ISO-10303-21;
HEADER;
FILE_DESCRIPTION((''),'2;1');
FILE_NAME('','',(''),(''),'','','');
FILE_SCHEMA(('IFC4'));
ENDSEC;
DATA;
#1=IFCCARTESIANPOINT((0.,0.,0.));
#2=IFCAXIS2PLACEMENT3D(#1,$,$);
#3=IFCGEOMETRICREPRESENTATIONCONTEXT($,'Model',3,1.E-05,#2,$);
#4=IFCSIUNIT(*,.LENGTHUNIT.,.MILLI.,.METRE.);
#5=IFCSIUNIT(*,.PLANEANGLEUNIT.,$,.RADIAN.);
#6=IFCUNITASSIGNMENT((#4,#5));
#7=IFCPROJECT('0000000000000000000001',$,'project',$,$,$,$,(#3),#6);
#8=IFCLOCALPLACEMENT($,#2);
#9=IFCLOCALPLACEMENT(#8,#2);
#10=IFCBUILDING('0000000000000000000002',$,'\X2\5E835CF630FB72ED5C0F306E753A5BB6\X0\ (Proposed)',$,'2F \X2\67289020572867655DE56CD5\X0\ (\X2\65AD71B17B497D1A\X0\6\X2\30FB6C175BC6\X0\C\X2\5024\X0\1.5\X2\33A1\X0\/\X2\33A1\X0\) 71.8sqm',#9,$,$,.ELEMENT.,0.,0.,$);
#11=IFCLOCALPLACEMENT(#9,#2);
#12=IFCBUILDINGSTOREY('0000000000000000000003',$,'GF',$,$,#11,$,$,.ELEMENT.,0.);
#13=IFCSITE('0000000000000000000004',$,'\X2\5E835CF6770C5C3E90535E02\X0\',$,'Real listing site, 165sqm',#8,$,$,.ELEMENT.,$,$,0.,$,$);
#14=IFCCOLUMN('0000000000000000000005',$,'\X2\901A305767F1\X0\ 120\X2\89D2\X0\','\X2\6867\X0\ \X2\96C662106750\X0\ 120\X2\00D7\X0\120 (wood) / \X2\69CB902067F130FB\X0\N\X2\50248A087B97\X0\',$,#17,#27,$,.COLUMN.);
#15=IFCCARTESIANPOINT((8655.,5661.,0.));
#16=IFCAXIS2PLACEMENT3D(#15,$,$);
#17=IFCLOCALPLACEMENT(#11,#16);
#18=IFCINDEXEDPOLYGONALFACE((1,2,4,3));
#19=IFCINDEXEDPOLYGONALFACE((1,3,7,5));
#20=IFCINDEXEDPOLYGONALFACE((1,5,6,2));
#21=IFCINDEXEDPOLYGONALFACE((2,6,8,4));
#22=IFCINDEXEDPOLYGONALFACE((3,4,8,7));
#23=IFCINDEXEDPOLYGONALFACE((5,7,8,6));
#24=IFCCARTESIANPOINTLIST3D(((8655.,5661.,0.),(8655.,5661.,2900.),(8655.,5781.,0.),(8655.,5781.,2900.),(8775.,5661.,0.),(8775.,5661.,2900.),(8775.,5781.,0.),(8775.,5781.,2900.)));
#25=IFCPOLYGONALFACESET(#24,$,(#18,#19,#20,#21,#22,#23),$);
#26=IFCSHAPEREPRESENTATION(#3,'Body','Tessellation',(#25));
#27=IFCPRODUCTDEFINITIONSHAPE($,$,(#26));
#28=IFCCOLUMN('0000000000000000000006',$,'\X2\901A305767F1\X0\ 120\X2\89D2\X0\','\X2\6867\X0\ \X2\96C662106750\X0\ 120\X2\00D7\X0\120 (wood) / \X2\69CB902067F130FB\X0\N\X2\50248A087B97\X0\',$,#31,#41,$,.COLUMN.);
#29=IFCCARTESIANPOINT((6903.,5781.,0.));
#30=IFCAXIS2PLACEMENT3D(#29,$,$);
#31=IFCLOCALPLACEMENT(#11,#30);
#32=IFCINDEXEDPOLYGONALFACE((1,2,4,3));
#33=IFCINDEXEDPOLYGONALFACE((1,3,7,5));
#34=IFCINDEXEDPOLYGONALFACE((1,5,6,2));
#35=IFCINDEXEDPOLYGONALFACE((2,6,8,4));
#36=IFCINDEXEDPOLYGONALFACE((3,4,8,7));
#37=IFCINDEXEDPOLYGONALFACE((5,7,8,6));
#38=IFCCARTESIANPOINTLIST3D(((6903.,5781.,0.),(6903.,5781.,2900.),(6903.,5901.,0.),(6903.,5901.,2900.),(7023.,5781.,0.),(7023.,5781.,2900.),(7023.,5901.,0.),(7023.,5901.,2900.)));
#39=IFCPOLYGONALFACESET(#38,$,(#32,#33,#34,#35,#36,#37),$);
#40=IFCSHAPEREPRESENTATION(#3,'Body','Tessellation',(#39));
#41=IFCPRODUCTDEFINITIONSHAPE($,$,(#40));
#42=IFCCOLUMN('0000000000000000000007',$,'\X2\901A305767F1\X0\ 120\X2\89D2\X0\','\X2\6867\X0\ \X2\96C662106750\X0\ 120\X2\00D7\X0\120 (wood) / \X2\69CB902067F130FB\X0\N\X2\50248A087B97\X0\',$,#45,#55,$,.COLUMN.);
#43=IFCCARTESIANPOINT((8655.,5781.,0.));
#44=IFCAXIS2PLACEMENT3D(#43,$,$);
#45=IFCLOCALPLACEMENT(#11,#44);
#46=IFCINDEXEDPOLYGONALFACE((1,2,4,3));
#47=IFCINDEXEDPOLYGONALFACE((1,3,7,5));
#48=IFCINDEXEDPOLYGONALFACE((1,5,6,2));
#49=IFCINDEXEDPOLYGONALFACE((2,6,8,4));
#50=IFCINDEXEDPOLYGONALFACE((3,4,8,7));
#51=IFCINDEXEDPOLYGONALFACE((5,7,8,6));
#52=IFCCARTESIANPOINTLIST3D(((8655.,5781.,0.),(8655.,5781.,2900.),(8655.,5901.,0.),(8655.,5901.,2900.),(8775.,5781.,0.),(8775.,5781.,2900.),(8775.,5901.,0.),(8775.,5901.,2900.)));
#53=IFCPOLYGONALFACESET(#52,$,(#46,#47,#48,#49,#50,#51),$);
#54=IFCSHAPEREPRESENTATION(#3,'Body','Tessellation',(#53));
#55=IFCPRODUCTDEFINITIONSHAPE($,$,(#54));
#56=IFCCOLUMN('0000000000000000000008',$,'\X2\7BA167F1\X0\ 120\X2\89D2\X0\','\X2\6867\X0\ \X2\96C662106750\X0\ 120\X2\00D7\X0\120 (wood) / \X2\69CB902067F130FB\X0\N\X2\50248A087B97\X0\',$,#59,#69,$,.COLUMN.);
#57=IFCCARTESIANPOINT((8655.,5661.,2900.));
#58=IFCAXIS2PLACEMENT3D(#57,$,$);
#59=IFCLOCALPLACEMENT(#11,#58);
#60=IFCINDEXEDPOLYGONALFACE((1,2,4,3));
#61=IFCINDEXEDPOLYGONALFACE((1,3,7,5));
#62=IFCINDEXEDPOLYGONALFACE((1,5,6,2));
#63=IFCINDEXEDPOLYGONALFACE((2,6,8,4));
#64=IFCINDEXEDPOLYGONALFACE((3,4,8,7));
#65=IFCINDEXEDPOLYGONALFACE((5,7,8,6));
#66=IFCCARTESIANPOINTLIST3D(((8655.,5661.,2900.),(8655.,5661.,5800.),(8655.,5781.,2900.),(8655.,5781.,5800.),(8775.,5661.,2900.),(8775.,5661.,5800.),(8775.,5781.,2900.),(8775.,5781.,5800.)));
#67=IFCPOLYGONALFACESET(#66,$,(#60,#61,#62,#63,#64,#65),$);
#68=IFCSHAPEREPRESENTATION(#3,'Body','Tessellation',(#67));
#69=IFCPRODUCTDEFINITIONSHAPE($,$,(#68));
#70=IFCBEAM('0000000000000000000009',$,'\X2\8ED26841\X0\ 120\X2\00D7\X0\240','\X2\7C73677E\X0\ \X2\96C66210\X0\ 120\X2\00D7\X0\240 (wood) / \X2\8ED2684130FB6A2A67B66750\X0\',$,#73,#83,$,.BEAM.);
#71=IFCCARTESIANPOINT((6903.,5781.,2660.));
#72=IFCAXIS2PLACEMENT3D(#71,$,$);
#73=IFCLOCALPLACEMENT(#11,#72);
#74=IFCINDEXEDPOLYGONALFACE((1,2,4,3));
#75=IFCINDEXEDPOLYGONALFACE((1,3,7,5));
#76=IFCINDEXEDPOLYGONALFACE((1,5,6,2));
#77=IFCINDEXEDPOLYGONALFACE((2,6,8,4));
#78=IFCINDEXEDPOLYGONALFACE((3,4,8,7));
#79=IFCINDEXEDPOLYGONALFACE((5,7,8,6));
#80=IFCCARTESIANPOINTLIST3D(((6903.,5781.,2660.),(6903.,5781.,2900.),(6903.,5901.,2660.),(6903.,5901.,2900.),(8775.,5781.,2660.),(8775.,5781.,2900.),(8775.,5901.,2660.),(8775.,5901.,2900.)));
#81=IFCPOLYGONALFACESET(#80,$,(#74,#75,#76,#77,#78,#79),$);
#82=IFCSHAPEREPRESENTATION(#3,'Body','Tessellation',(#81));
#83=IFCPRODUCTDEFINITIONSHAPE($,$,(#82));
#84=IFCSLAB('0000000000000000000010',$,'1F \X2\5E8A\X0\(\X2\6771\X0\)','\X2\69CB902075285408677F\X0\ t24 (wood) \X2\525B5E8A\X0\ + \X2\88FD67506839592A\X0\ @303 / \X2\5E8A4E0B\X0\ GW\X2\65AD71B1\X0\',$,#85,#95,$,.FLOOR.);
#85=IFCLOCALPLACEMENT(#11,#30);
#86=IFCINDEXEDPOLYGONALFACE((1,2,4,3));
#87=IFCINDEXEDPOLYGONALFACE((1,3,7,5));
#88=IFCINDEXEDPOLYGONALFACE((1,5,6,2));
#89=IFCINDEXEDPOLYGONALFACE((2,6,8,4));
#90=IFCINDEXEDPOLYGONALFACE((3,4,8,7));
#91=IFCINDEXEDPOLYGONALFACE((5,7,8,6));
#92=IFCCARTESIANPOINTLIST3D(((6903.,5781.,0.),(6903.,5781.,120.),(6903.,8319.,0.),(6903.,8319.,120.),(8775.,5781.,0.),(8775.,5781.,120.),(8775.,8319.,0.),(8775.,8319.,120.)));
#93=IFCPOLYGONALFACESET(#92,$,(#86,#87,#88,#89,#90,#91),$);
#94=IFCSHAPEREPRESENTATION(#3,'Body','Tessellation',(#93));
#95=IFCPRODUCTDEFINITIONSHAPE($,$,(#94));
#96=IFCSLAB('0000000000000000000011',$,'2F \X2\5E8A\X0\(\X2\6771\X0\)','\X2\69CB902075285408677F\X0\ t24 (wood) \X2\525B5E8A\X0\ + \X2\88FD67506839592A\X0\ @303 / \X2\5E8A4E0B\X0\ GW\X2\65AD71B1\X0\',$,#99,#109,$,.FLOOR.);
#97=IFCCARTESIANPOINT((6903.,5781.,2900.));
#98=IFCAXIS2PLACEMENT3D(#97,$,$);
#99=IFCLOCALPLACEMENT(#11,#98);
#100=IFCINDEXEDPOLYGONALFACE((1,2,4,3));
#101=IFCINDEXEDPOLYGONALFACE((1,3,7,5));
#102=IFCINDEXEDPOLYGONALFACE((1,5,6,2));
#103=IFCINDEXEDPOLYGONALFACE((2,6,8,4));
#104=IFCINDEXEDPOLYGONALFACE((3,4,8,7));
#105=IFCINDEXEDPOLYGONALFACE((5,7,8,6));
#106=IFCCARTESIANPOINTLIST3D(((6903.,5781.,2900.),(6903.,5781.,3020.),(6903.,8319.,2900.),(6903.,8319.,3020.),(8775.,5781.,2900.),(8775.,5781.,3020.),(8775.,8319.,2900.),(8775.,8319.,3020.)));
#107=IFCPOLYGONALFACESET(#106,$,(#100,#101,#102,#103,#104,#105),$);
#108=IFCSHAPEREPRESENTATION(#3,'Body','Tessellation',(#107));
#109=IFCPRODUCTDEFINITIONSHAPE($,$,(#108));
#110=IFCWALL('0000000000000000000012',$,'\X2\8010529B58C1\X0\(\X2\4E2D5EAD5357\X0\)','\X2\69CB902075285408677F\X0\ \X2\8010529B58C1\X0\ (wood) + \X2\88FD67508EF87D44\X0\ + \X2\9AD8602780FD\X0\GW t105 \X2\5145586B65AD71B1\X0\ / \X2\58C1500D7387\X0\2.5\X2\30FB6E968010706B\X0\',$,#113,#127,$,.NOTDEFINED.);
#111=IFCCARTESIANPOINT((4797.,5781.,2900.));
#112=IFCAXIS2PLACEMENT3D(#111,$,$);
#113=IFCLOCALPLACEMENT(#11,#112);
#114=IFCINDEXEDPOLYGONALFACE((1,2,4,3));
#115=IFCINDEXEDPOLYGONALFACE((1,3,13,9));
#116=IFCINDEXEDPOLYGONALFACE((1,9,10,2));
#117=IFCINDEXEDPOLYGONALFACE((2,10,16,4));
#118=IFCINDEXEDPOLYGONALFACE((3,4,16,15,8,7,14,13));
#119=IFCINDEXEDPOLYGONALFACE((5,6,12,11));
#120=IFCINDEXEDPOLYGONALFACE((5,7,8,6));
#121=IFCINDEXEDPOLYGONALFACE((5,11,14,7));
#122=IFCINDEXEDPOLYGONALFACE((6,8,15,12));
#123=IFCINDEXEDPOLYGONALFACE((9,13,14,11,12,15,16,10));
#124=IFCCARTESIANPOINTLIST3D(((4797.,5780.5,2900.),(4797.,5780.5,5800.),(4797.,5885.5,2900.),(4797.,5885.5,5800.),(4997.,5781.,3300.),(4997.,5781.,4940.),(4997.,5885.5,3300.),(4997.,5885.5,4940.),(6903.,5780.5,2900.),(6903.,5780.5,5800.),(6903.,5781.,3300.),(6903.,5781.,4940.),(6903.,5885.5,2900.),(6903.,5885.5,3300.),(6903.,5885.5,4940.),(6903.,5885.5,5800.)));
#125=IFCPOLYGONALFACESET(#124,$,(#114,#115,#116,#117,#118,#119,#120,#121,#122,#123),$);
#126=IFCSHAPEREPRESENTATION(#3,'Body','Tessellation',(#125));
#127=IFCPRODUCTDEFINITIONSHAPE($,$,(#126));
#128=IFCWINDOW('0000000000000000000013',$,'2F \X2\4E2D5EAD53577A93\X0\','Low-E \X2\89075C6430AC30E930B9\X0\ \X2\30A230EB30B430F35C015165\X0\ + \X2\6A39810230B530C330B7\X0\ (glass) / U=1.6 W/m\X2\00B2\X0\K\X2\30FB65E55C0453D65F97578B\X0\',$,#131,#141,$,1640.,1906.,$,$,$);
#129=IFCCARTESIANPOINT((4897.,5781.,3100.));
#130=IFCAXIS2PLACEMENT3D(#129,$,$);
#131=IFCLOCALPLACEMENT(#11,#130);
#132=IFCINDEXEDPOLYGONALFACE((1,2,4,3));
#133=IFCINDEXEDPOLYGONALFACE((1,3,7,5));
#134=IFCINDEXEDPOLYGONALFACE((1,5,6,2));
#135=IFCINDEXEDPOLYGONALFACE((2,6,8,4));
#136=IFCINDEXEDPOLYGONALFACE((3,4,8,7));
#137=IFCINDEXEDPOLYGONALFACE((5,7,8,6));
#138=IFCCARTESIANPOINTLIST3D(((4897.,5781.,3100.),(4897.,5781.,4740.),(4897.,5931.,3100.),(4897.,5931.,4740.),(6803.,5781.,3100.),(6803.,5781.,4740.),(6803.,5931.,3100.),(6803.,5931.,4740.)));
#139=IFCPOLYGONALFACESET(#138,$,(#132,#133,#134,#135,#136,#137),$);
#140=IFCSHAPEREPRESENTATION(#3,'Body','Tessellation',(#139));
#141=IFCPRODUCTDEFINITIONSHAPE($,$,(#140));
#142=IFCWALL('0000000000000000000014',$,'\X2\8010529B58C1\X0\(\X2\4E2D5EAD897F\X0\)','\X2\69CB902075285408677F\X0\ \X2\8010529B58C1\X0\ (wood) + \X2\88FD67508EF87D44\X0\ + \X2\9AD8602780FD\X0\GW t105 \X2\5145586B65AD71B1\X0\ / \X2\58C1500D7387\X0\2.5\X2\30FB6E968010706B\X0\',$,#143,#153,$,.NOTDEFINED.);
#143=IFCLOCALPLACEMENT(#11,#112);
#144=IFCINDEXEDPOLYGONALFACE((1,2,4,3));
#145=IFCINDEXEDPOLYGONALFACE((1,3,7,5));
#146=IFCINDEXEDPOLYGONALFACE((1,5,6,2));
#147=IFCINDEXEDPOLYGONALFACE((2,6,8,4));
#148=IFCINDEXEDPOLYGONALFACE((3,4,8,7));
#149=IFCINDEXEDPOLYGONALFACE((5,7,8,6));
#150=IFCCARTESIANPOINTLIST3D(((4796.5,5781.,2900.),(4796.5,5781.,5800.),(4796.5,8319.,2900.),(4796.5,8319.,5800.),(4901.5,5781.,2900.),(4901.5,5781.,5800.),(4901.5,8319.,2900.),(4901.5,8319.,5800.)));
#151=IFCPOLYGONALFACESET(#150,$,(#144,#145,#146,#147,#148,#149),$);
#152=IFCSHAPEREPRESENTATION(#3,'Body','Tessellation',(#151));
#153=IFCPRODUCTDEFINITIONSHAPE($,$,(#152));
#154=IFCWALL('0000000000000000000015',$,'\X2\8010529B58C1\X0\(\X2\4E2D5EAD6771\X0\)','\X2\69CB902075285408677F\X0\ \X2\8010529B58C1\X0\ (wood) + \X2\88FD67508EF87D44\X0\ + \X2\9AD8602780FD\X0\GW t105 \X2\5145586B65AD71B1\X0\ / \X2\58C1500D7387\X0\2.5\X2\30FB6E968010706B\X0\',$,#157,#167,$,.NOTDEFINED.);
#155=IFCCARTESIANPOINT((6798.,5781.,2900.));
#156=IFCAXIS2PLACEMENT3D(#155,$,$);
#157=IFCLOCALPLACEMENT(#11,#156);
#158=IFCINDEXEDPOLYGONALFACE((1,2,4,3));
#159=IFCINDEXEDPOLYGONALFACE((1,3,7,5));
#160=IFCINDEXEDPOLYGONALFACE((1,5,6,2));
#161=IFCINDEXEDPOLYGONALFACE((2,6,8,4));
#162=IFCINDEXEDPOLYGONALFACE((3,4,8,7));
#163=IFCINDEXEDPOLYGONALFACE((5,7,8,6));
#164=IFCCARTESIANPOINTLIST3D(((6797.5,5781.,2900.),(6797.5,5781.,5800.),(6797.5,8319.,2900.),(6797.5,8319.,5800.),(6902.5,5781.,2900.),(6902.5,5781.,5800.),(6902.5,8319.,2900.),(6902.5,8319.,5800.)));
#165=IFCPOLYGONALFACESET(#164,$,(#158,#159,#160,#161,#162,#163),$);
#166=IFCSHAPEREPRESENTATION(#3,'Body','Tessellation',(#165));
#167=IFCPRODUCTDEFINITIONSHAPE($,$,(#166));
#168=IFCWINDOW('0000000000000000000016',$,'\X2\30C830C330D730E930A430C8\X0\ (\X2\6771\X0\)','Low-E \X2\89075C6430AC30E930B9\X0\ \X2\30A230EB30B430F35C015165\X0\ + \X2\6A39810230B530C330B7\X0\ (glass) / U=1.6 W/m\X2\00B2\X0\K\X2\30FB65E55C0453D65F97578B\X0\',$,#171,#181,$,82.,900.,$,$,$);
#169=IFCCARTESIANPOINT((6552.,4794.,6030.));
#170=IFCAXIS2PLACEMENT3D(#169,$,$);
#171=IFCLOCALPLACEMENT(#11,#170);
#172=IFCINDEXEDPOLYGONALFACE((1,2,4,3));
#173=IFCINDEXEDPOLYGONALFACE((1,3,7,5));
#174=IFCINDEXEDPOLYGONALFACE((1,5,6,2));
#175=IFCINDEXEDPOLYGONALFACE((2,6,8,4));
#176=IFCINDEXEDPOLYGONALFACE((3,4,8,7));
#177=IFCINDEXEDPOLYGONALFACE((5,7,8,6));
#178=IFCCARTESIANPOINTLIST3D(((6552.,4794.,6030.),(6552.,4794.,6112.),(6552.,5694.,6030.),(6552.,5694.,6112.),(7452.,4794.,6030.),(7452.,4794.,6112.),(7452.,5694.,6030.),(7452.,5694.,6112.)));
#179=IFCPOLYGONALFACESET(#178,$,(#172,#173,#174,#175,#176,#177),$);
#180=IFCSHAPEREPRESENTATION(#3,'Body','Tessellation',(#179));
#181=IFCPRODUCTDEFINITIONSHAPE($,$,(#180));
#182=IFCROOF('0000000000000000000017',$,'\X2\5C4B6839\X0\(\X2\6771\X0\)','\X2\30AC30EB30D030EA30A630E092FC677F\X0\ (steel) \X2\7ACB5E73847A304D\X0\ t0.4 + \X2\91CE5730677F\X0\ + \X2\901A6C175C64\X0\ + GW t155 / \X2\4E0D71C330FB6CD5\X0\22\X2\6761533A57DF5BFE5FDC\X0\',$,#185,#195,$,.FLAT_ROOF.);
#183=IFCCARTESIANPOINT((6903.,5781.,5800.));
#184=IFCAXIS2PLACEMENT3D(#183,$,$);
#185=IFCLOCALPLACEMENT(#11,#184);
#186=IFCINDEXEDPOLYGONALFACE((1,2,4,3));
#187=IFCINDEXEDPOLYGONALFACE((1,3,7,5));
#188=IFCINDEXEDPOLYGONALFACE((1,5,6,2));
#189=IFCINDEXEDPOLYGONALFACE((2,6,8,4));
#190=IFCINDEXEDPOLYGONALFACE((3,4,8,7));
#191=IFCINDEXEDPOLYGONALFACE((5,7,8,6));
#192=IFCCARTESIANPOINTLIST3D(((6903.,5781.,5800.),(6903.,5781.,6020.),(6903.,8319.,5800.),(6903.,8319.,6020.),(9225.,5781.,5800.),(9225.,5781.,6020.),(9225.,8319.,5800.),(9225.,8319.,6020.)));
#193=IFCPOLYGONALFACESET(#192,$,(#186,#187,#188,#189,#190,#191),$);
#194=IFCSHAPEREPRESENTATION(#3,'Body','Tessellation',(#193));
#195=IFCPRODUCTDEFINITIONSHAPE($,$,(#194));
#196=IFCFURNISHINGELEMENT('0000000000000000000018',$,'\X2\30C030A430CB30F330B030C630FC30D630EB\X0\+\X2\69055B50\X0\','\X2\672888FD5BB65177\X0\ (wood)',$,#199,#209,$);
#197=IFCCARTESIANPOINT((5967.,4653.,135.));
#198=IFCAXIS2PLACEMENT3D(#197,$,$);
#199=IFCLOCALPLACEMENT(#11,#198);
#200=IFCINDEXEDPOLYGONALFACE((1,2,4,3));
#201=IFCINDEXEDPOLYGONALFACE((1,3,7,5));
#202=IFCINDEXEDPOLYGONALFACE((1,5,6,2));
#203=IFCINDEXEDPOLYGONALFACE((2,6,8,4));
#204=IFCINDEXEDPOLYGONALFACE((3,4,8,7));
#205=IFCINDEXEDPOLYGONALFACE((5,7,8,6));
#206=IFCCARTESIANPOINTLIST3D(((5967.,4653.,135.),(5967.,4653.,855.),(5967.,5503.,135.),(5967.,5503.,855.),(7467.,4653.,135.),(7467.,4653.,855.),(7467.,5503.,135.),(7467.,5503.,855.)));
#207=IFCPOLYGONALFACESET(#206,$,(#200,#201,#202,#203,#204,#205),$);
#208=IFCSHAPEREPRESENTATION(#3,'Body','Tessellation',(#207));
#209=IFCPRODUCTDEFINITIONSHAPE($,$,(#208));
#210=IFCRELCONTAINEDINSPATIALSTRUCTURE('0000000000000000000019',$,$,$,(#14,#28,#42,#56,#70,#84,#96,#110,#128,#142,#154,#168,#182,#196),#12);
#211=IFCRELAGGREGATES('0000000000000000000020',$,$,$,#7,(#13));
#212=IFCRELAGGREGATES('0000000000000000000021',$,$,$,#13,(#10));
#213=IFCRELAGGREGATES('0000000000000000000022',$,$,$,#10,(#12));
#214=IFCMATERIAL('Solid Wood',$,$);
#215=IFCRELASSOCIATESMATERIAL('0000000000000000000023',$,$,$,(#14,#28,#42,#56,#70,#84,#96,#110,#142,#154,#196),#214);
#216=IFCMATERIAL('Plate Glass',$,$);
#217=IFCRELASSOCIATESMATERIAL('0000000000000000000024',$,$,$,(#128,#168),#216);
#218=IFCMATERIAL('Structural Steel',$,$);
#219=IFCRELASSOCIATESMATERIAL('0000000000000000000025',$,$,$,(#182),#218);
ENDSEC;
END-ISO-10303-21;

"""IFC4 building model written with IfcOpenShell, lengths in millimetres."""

from ifc_helpers import new_model, si_unit, frame, frame_2d, origin, place, context, project, spatial, rectangle, extrude, material, element, fill, save


model = new_model("IFC4")

# Units and contexts
model_context = context("Model", 3, precision=1e-05, world=origin())
ifc_project = project(units=[si_unit("LENGTHUNIT", "METRE", prefix="MILLI"), si_unit("PLANEANGLEUNIT", "RADIAN")], contexts=[model_context])

# Site, building, storey
site_placement = place(None, origin())
site = spatial("IfcSite", under=ifc_project, at=site_placement, Name="広島県尾道市", ObjectType="Real listing site, 165sqm", CompositionType="ELEMENT", RefElevation=0.0)
building_placement = place(site_placement, origin())
building = spatial("IfcBuilding", under=site, at=building_placement, Name="広島・狭小の町家 (Proposed)", ObjectType="2F 木造在来工法 (断熱等級6・気密C値1.5㎡/㎡) 71.8sqm", CompositionType="ELEMENT", ElevationOfRefHeight=0.0, ElevationOfTerrain=0.0)
storey_placement = place(building_placement, origin())
storey = spatial("IfcBuildingStorey", under=building, at=storey_placement, Name="GF", CompositionType="ELEMENT", Elevation=0.0)

# Columns
ifc_material_1 = material(Name="Solid Wood")
column_1_placement = place(storey_placement, frame((8655.0, 5661.0, 0.0)))
element("IfcColumn", 1, at=column_1_placement, inside=storey, material=ifc_material_1, Name="通し柱 120角", Description="桧 集成材 120×120 (wood) / 構造柱・N値計算", PredefinedType="COLUMN", context=model_context, shape_type="SweptSolid", body=[
    extrude(rectangle(XDim=120.0, YDim=120.0, at=frame_2d((60.0, 60.0))), frame((8655.0, 5661.0, 0.0)), (0.0, 0.0, 1.0), 2900.0),
])
column_2_placement = place(storey_placement, frame((6903.0, 5781.0, 0.0)))
element("IfcColumn", 2, at=column_2_placement, inside=storey, material=ifc_material_1, Name="通し柱 120角", Description="桧 集成材 120×120 (wood) / 構造柱・N値計算", PredefinedType="COLUMN", context=model_context, shape_type="SweptSolid", body=[
    extrude(rectangle(XDim=120.0, YDim=120.0, at=frame_2d((60.0, 60.0))), frame((6903.0, 5781.0, 0.0)), (0.0, 0.0, 1.0), 2900.0),
])
column_3_placement = place(storey_placement, frame((8655.0, 5781.0, 0.0)))
element("IfcColumn", 3, at=column_3_placement, inside=storey, material=ifc_material_1, Name="通し柱 120角", Description="桧 集成材 120×120 (wood) / 構造柱・N値計算", PredefinedType="COLUMN", context=model_context, shape_type="SweptSolid", body=[
    extrude(rectangle(XDim=120.0, YDim=120.0, at=frame_2d((60.0, 60.0))), frame((8655.0, 5781.0, 0.0)), (0.0, 0.0, 1.0), 2900.0),
])
column_4_placement = place(storey_placement, frame((8655.0, 5661.0, 2900.0)))
element("IfcColumn", 4, at=column_4_placement, inside=storey, material=ifc_material_1, Name="管柱 120角", Description="桧 集成材 120×120 (wood) / 構造柱・N値計算", PredefinedType="COLUMN", context=model_context, shape_type="SweptSolid", body=[
    extrude(rectangle(XDim=120.0, YDim=120.0, at=frame_2d((60.0, 60.0))), frame((8655.0, 5661.0, 2900.0)), (0.0, 0.0, 1.0), 2900.0),
])

# Beam
beam_1_placement = place(storey_placement, frame((6903.0, 5781.0, 2660.0)))
element("IfcBeam", 5, at=beam_1_placement, inside=storey, material=ifc_material_1, Name="軒桁 120×240", Description="米松 集成 120×240 (wood) / 軒桁・横架材", PredefinedType="BEAM", context=model_context, shape_type="SweptSolid", body=[
    extrude(rectangle(XDim=1872.0, YDim=120.0, at=frame_2d((936.0, 60.0))), frame((6903.0, 5781.0, 2660.0)), (0.0, 0.0, 1.0), 240.0),
])

# Slabs
slab_1_placement = place(storey_placement, frame((6903.0, 5781.0, 0.0)))
element("IfcSlab", 6, at=slab_1_placement, inside=storey, material=ifc_material_1, Name="1F 床(東)", Description="構造用合板 t24 (wood) 剛床 + 製材根太 @303 / 床下 GW断熱", PredefinedType="FLOOR", context=model_context, shape_type="SweptSolid", body=[
    extrude(rectangle(XDim=1872.0, YDim=2538.0, at=frame_2d((936.0, 1269.0))), frame((6903.0, 5781.0, 0.0)), (0.0, 0.0, 1.0), 120.0),
])
slab_2_placement = place(storey_placement, frame((6903.0, 5781.0, 2900.0)))
element("IfcSlab", 7, at=slab_2_placement, inside=storey, material=ifc_material_1, Name="2F 床(東)", Description="構造用合板 t24 (wood) 剛床 + 製材根太 @303 / 床下 GW断熱", PredefinedType="FLOOR", context=model_context, shape_type="SweptSolid", body=[
    extrude(rectangle(XDim=1872.0, YDim=2538.0, at=frame_2d((936.0, 1269.0))), frame((6903.0, 5781.0, 2900.0)), (0.0, 0.0, 1.0), 120.0),
])

# Wall, opening, window
wall_1_placement = place(storey_placement, frame((4797.0, 5781.0, 2900.0)))
wall_1 = element("IfcWall", 8, at=wall_1_placement, inside=storey, material=ifc_material_1, Name="耐力壁(中庭南)", Description="構造用合板 耐力壁 (wood) + 製材軸組 + 高性能GW t105 充填断熱 / 壁倍率2.5・準耐火", PredefinedType="NOTDEFINED", context=model_context, shape_type="SweptSolid", body=[
    extrude(rectangle(XDim=2106.0, YDim=105.0, at=frame_2d((1053.0, 52.0))), frame((4797.0, 5781.0, 2900.0)), (0.0, 0.0, 1.0), 2900.0),
])
opening_placement = place(storey_placement, frame((4897.0, 5781.0, 3100.0)))
opening = element("IfcOpeningElement", 9, at=opening_placement, cuts=wall_1, PredefinedType="NOTDEFINED", context=model_context, shape_type="SweptSolid", body=[
    extrude(rectangle(XDim=1906.0, YDim=150.0, at=frame_2d((953.0, 75.0))), frame((4897.0, 5781.0, 3100.0)), (0.0, 0.0, 1.0), 1640.0),
])
ifc_material_2 = material(Name="Plate Glass")
window_1_placement = place(storey_placement, frame((4897.0, 5781.0, 3100.0)))
window_1 = element("IfcWindow", 10, at=window_1_placement, inside=storey, material=ifc_material_2, Name="2F 中庭南窓", Description="Low-E 複層ガラス アルゴン封入 + 樹脂サッシ (glass) / U=1.6 W/m²K・日射取得型", OverallHeight=1640.0, OverallWidth=1906.0, context=model_context, shape_type="SweptSolid", body=[
    extrude(rectangle(XDim=1906.0, YDim=150.0, at=frame_2d((953.0, 75.0))), frame((4897.0, 5781.0, 3100.0)), (0.0, 0.0, 1.0), 1640.0),
])
fill(opening, window_1)

# Walls
wall_2_placement = place(storey_placement, frame((4797.0, 5781.0, 2900.0)))
element("IfcWall", 11, at=wall_2_placement, inside=storey, material=ifc_material_1, Name="耐力壁(中庭西)", Description="構造用合板 耐力壁 (wood) + 製材軸組 + 高性能GW t105 充填断熱 / 壁倍率2.5・準耐火", PredefinedType="NOTDEFINED", context=model_context, shape_type="SweptSolid", body=[
    extrude(rectangle(XDim=105.0, YDim=2538.0, at=frame_2d((52.0, 1269.0))), frame((4797.0, 5781.0, 2900.0)), (0.0, 0.0, 1.0), 2900.0),
])
wall_3_placement = place(storey_placement, frame((6798.0, 5781.0, 2900.0)))
element("IfcWall", 12, at=wall_3_placement, inside=storey, material=ifc_material_1, Name="耐力壁(中庭東)", Description="構造用合板 耐力壁 (wood) + 製材軸組 + 高性能GW t105 充填断熱 / 壁倍率2.5・準耐火", PredefinedType="NOTDEFINED", context=model_context, shape_type="SweptSolid", body=[
    extrude(rectangle(XDim=105.0, YDim=2538.0, at=frame_2d((52.0, 1269.0))), frame((6798.0, 5781.0, 2900.0)), (0.0, 0.0, 1.0), 2900.0),
])

# Window
window_2_placement = place(storey_placement, frame((6552.0, 4794.0, 6030.0)))
element("IfcWindow", 13, at=window_2_placement, inside=storey, material=ifc_material_2, Name="トップライト (東)", Description="Low-E 複層ガラス アルゴン封入 + 樹脂サッシ (glass) / U=1.6 W/m²K・日射取得型", OverallHeight=82.0, OverallWidth=900.0, context=model_context, shape_type="SweptSolid", body=[
    extrude(rectangle(XDim=900.0, YDim=900.0, at=frame_2d((450.0, 450.0))), frame((6552.0, 4794.0, 6030.0)), (0.0, 0.0, 1.0), 82.0),
])

# Roof
ifc_material_3 = material(Name="Structural Steel")
for number, where, name in (
    (14, (6903.0, 5781.0, 5800.0), "屋根(東)"),
):
    element("IfcRoof", number, at=place(storey_placement, frame(where)), inside=storey, material=ifc_material_3, Name=name, Description="ガルバリウム鋼板 (steel) 立平葺き t0.4 + 野地板 + 通気層 + GW t155 / 不燃・法22条区域対応", PredefinedType="FLAT_ROOF", context=model_context, shape_type="SweptSolid", body=[
        extrude(rectangle(XDim=2322.0, YDim=2538.0, at=frame_2d((1161.0, 1269.0))), frame((6903.0, 5781.0, 5800.0)), (0.0, 0.0, 1.0), 220.0),
    ])

# Furnishing element
furnishing_1_placement = place(storey_placement, frame((5967.0, 4653.0, 135.0)))
element("IfcFurnishingElement", 15, at=furnishing_1_placement, inside=storey, material=ifc_material_1, Name="ダイニングテーブル+椅子", Description="木製家具 (wood)", context=model_context, shape_type="SweptSolid", body=[
    extrude(rectangle(XDim=1500.0, YDim=850.0, at=frame_2d((750.0, 425.0))), frame((5967.0, 4653.0, 135.0)), (0.0, 0.0, 1.0), 720.0),
])

save(model, "model.ifc")
